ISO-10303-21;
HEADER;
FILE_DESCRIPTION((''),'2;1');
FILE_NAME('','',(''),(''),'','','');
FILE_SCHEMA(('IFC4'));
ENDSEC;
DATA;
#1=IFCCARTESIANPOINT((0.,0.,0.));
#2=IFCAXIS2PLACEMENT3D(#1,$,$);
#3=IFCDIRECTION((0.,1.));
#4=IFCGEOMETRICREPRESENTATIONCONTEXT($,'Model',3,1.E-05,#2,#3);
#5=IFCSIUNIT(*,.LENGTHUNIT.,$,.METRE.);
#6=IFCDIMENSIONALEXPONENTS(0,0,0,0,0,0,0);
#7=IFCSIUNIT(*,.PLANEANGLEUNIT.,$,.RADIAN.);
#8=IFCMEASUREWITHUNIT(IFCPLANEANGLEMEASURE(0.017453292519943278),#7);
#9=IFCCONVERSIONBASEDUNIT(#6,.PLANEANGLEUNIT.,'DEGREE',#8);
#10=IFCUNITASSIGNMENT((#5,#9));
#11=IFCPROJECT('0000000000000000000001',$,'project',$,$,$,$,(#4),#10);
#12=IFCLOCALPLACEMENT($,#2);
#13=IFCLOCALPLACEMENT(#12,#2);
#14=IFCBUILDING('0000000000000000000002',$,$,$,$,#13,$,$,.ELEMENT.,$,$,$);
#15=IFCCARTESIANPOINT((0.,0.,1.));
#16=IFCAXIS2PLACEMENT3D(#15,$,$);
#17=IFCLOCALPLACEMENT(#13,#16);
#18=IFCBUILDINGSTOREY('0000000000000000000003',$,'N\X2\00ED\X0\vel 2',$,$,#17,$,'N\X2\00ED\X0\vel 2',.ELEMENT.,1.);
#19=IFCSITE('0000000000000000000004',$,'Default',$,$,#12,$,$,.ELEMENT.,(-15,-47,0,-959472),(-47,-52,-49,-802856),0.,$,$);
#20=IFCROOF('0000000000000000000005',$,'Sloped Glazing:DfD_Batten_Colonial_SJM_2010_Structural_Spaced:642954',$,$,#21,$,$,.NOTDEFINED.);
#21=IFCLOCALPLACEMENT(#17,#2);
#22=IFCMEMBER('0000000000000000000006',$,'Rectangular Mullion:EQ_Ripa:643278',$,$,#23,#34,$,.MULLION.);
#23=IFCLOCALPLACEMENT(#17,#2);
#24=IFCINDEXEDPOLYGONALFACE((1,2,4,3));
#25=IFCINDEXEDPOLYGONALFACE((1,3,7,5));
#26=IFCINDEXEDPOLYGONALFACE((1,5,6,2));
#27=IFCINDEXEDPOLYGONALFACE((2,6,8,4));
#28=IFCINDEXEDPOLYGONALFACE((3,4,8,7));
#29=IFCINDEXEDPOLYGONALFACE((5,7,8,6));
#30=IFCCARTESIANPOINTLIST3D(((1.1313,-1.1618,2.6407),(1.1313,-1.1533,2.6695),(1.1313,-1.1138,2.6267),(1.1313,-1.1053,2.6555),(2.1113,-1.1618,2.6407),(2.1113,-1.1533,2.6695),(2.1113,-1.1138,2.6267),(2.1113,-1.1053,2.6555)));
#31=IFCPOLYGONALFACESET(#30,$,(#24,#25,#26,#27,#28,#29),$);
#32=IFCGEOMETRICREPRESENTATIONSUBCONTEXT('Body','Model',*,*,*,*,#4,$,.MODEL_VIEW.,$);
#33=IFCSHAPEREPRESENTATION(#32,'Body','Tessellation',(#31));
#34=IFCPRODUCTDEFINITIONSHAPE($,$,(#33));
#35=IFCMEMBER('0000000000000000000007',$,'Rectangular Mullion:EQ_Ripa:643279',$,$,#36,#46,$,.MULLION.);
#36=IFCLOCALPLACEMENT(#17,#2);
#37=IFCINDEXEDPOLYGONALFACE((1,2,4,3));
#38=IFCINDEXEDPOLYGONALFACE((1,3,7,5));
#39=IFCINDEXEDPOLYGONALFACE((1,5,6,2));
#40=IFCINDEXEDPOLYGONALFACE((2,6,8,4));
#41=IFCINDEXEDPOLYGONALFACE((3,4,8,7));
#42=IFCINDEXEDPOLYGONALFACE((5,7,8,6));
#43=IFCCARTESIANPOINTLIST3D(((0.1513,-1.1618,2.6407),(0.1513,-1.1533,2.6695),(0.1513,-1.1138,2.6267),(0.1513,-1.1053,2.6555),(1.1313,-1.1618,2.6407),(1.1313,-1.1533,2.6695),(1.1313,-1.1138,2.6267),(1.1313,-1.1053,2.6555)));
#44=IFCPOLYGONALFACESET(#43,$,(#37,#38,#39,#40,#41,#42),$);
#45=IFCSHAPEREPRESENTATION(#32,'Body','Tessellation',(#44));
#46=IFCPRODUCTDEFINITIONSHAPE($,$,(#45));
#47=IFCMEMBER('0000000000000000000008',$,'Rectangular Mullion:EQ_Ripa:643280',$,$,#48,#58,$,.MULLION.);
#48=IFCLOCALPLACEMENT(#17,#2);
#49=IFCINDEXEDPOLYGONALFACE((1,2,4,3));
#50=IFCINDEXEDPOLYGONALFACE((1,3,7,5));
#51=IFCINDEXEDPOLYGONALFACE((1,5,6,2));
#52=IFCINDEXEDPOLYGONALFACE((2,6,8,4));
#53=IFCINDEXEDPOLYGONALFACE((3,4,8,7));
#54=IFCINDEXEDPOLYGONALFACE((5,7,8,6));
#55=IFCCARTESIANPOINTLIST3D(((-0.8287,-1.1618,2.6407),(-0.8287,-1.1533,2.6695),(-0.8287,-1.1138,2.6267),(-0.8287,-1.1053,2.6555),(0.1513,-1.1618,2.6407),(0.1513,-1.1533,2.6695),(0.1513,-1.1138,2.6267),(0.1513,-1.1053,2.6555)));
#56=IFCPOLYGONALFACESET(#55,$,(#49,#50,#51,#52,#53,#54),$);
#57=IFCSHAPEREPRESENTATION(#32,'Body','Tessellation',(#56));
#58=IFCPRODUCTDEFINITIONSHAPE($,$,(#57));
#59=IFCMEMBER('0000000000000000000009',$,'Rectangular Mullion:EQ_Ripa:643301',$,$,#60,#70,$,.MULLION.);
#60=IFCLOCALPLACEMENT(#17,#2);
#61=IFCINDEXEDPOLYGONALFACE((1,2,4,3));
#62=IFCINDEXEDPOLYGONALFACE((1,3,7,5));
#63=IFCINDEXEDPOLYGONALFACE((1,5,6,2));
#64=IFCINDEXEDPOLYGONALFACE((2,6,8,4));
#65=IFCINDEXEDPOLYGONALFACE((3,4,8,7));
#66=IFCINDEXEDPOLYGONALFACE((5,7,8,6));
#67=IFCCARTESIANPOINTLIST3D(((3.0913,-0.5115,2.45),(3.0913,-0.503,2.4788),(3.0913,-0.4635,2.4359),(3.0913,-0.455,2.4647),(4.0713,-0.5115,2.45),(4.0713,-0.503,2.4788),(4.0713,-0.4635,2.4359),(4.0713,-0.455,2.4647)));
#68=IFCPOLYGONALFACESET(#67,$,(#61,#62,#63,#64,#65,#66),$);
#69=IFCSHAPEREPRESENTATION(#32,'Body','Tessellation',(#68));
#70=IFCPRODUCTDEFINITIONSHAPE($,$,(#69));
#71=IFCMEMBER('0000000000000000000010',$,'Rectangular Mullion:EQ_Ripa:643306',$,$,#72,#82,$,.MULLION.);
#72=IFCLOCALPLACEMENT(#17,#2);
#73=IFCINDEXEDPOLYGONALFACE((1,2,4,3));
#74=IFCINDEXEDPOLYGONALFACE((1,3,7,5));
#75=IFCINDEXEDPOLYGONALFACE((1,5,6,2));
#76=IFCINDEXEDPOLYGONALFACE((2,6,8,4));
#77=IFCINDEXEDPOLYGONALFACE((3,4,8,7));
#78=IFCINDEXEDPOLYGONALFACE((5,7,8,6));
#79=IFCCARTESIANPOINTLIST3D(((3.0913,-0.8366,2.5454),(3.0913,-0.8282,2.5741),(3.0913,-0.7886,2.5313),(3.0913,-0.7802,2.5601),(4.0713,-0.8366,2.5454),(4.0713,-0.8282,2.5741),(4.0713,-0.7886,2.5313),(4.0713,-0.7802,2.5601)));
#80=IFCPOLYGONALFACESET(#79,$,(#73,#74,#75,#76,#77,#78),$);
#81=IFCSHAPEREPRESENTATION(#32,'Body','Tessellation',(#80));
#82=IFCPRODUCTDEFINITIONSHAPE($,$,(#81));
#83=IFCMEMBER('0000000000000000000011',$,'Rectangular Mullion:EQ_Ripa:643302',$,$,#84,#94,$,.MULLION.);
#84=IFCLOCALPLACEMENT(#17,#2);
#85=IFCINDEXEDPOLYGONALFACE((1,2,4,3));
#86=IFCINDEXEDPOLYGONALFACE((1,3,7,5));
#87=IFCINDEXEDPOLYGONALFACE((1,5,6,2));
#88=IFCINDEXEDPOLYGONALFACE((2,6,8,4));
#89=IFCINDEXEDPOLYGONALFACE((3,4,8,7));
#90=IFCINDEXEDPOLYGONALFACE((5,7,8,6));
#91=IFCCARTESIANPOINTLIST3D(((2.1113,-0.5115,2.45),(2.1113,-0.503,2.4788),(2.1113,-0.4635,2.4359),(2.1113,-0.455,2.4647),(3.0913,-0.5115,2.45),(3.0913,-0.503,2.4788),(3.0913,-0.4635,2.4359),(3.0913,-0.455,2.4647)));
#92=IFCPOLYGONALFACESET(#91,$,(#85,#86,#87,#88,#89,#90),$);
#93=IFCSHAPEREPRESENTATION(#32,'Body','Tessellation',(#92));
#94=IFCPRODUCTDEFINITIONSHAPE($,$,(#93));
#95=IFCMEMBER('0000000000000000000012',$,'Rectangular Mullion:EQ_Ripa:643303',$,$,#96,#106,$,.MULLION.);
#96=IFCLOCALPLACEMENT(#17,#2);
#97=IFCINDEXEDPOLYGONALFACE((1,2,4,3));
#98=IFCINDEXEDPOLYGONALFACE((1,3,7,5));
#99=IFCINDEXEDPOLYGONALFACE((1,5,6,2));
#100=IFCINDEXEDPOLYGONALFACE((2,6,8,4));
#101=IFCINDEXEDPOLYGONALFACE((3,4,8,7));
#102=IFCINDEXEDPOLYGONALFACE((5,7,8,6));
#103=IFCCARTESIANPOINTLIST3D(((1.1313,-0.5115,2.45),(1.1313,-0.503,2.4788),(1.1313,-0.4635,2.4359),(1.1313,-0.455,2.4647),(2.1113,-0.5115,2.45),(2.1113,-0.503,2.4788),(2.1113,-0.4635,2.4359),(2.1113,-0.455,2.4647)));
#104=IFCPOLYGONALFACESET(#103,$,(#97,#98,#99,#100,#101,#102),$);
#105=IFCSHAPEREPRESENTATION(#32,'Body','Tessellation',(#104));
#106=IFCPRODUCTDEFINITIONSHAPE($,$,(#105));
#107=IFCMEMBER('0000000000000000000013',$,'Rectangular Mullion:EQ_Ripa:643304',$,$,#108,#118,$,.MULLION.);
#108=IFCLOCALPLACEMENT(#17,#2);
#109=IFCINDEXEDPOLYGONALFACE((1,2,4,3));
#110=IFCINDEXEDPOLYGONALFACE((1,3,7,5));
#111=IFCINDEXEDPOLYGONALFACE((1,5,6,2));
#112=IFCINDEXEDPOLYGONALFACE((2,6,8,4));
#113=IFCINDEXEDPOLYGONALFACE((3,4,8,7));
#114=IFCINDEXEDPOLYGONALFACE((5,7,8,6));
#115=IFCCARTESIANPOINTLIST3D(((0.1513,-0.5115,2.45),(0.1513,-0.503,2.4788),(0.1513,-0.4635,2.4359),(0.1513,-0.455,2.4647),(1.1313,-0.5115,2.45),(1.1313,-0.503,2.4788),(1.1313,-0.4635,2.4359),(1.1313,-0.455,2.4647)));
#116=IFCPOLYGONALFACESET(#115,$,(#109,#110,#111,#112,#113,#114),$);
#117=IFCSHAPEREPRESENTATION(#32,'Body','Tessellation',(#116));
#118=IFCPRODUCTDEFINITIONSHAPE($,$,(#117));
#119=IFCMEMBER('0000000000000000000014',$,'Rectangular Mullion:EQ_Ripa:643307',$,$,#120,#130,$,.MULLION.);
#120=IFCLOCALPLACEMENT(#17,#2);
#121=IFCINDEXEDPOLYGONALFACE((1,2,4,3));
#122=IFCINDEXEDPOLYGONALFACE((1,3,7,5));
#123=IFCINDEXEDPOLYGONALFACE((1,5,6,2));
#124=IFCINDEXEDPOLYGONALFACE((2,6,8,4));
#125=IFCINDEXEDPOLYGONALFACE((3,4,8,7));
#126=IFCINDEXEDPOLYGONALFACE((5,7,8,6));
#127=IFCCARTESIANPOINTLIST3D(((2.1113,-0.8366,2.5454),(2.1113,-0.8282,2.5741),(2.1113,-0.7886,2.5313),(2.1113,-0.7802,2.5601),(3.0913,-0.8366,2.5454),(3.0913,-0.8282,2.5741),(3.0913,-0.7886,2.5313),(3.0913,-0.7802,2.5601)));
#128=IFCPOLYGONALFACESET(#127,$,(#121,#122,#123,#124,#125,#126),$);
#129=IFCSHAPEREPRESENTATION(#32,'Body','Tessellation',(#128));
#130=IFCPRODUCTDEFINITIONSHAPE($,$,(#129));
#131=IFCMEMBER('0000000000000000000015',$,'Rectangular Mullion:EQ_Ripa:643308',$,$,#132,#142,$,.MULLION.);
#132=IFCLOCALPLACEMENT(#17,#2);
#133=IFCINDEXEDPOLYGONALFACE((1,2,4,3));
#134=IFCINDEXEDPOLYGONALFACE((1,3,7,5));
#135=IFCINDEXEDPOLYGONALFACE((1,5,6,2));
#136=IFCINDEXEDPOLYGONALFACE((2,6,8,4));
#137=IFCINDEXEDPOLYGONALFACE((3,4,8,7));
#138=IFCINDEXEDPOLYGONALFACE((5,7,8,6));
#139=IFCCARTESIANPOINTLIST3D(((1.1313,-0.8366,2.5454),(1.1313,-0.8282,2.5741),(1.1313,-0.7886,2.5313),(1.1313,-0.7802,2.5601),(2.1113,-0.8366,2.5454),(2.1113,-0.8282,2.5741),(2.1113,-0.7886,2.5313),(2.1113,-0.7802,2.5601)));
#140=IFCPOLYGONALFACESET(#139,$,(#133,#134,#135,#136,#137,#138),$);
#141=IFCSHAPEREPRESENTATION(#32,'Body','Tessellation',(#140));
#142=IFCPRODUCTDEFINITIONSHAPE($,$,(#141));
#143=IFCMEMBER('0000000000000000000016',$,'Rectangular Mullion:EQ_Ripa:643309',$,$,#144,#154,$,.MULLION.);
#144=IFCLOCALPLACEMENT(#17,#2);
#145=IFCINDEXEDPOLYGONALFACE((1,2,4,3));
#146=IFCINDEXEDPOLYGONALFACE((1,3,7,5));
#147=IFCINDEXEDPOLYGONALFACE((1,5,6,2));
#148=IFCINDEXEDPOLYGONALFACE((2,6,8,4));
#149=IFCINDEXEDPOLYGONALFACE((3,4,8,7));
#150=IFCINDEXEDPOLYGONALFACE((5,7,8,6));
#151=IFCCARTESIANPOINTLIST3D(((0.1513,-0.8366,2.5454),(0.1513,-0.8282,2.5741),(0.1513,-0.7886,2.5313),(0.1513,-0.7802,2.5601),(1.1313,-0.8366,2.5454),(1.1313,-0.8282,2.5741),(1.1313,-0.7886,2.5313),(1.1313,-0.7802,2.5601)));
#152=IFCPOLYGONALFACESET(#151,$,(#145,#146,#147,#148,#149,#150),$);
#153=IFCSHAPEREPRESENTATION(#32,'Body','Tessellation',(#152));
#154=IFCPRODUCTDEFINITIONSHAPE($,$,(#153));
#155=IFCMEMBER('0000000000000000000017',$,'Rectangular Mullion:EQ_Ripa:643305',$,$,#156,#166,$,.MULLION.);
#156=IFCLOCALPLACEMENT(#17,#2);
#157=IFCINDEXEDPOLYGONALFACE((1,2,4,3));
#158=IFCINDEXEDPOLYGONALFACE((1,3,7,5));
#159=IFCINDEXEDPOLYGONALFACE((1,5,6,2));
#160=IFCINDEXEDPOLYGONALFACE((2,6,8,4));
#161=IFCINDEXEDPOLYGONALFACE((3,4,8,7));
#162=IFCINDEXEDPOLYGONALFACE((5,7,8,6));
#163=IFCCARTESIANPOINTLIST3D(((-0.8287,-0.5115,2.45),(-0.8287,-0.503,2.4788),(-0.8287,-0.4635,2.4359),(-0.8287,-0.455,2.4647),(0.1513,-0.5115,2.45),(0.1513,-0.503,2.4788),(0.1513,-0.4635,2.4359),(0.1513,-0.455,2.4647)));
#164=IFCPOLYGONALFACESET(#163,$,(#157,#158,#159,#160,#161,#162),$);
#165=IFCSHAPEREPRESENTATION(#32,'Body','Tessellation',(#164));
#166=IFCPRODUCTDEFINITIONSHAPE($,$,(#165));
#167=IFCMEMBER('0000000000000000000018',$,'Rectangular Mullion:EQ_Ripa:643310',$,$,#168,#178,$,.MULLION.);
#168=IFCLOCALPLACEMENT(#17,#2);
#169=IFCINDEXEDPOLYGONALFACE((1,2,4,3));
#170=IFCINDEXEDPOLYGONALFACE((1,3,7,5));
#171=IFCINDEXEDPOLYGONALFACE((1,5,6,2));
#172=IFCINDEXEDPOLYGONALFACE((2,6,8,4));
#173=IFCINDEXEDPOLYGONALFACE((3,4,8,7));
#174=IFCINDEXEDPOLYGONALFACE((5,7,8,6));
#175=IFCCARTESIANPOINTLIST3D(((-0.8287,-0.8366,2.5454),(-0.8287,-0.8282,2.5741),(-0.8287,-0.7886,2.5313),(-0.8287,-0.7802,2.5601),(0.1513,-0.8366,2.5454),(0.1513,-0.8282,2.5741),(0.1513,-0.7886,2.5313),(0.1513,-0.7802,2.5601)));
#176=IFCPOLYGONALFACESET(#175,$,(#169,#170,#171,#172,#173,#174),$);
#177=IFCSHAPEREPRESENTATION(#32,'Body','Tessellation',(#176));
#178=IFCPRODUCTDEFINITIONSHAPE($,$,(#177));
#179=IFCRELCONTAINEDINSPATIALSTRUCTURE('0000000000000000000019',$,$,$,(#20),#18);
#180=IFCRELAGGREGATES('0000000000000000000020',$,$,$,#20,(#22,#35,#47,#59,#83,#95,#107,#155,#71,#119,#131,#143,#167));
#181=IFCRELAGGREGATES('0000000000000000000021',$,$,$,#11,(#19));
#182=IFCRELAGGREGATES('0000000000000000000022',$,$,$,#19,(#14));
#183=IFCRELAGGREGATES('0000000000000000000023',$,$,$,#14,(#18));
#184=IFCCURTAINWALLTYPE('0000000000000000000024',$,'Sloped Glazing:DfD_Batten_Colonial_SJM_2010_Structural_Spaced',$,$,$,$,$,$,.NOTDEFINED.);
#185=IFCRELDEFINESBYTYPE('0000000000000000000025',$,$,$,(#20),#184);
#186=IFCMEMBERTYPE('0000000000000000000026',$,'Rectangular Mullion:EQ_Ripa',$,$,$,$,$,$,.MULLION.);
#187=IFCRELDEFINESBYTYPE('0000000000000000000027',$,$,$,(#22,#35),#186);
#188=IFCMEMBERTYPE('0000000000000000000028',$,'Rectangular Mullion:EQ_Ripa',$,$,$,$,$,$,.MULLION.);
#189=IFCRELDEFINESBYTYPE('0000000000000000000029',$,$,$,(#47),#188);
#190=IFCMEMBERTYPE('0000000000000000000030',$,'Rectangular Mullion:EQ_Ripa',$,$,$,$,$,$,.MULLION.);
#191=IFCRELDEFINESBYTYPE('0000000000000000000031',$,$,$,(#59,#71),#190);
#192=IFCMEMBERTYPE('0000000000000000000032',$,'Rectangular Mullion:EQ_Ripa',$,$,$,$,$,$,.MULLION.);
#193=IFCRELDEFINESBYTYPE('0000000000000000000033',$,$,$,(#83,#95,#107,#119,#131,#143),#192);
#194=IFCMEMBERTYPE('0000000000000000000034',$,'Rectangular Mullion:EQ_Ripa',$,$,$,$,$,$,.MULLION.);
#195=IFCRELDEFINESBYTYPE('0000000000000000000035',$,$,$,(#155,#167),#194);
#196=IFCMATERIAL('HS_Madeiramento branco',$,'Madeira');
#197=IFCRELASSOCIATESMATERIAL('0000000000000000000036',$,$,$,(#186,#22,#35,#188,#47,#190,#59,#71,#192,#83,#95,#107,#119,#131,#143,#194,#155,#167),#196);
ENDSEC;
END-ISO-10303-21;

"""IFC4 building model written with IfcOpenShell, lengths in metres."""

from ifc_helpers import new_model, entity, si_unit, converted_unit, direction, frame, origin, place, context, subcontext, project, spatial, indexed_curve, outline, extrude, source, transform, mapped, material, type_object, type_shapes, element, aggregate, save


model = new_model("IFC4")

# Units and contexts
model_context = context("Model", 3, precision=1e-05, world=origin(), true_north=direction((0.0, 1.0)))
body_context = subcontext(model_context, "Body", "Model", "MODEL_VIEW")
ifc_project = project(units=[si_unit("LENGTHUNIT", "METRE"), converted_unit("PLANEANGLEUNIT", "DEGREE", entity("IfcPlaneAngleMeasure", 0.017453292519943278), si_unit("PLANEANGLEUNIT", "RADIAN"), dimensions=[0, 0, 0, 0, 0, 0, 0])], contexts=[model_context])

# Site, building, storey
site_placement = place(None, origin())
site = spatial("IfcSite", under=ifc_project, at=site_placement, Name="Default", CompositionType="ELEMENT", RefLatitude=(-15, -47, 0, -959472), RefLongitude=(-47, -52, -49, -802856), RefElevation=0.0)
building_placement = place(site_placement, origin())
building = spatial("IfcBuilding", under=site, at=building_placement, CompositionType="ELEMENT")
storey_placement = place(building_placement, frame((0.0, 0.0, 1.0)))
storey = spatial("IfcBuildingStorey", under=building, at=storey_placement, Name="Nível 2", LongName="Nível 2", CompositionType="ELEMENT", Elevation=1.0)

# Roof, members
ifc_material_1 = material(Name="HS_Madeiramento branco", Category="Madeira")
curtain_wall_type_1 = type_object("IfcCurtainWallType", Name="Sloped Glazing:DfD_Batten_Colonial_SJM_2010_Structural_Spaced", PredefinedType="NOTDEFINED")
roof_1_placement = place(storey_placement, frame((0.0, 0.0, -1.0)))
roof_1 = element("IfcRoof", 1, at=roof_1_placement, inside=storey, type_object=curtain_wall_type_1, Name="Sloped Glazing:DfD_Batten_Colonial_SJM_2010_Structural_Spaced:642954", PredefinedType="NOTDEFINED")
member_type_1 = type_object("IfcMemberType", Name="Rectangular Mullion:EQ_Ripa", PredefinedType="MULLION", material=ifc_material_1)
shared_shape_1 = source(origin(), body_context, "Body", "SweptSolid", [
    extrude(outline(indexed_curve([(-0.025, -0.015), (0.025, -0.015), (0.025, 0.015), (-0.025, 0.015), (-0.025, -0.015)], self_intersect=False)), frame((-0.025, 0.0, -0.98), z_axis=(0.0, 0.0, 1.0), x_axis=(-1.0, 0.0, 0.0)), (0.0, 0.0, 1.0), 0.98),
])
type_shapes(member_type_1, [shared_shape_1])
member_1_placement = place(roof_1_placement, frame((2.1113, -1.1575, 3.6551), z_axis=(1.0, 0.0, 0.0), x_axis=(0.0, -0.95956, 0.281504)))
member_1 = element("IfcMember", 2, at=member_1_placement, type_object=member_type_1, material=ifc_material_1, Name="Rectangular Mullion:EQ_Ripa:643278", PredefinedType="MULLION", context=body_context, shape_type="MappedRepresentation", body=[
    mapped(shared_shape_1, transform((0.0, 0.0, 0.0), scale=1.0)),
])
member_2_placement = place(roof_1_placement, frame((1.1313, -1.1575, 3.6551), z_axis=(1.0, 0.0, 0.0), x_axis=(0.0, -0.95956, 0.281504)))
member_2 = element("IfcMember", 3, at=member_2_placement, type_object=member_type_1, material=ifc_material_1, Name="Rectangular Mullion:EQ_Ripa:643279", PredefinedType="MULLION", context=body_context, shape_type="MappedRepresentation", body=[
    mapped(shared_shape_1, transform((0.0, 0.0, 0.0), scale=1.0)),
])
member_type_2 = type_object("IfcMemberType", Name="Rectangular Mullion:EQ_Ripa", PredefinedType="MULLION", material=ifc_material_1)
shared_shape_2 = source(origin(), body_context, "Body", "SweptSolid", [
    extrude(outline(indexed_curve([(-0.025, -0.015), (0.025, -0.015), (0.025, 0.015), (-0.025, 0.015), (-0.025, -0.015)], self_intersect=False)), frame((-0.025, 0.0, -0.98), z_axis=(0.0, 0.0, 1.0), x_axis=(-1.0, 0.0, 0.0)), (0.0, 0.0, 1.0), 0.98),
])
type_shapes(member_type_2, [shared_shape_2])
member_3_placement = place(roof_1_placement, frame((0.1513, -1.1575, 3.6551), z_axis=(1.0, 0.0, 0.0), x_axis=(0.0, -0.95956, 0.281504)))
member_3 = element("IfcMember", 4, at=member_3_placement, type_object=member_type_2, material=ifc_material_1, Name="Rectangular Mullion:EQ_Ripa:643280", PredefinedType="MULLION", context=body_context, shape_type="MappedRepresentation", body=[
    mapped(shared_shape_2, transform((0.0, 0.0, 0.0), scale=1.0)),
])
member_type_3 = type_object("IfcMemberType", Name="Rectangular Mullion:EQ_Ripa", PredefinedType="MULLION", material=ifc_material_1)
shared_shape_3 = source(origin(), body_context, "Body", "SweptSolid", [
    extrude(outline(indexed_curve([(-0.025, -0.015), (0.025, -0.015), (0.025, 0.015), (-0.025, 0.015), (-0.025, -0.015)], self_intersect=False)), frame((0.0, 0.0, -0.98), z_axis=(0.0, 0.0, 1.0), x_axis=(-1.0, 0.0, 0.0)), (0.0, 0.0, 1.0), 0.98),
])
type_shapes(member_type_3, [shared_shape_3])
member_4_placement = place(roof_1_placement, frame((4.0713, -0.4833, 3.4573), z_axis=(1.0, 0.0, 0.0), x_axis=(0.0, -0.95956, 0.281504)))
member_4 = element("IfcMember", 5, at=member_4_placement, type_object=member_type_3, material=ifc_material_1, Name="Rectangular Mullion:EQ_Ripa:643301", PredefinedType="MULLION", context=body_context, shape_type="MappedRepresentation", body=[
    mapped(shared_shape_3, transform((0.0, 0.0, 0.0), scale=1.0)),
])
member_5_placement = place(roof_1_placement, frame((4.0713, -0.8084, 3.5527), z_axis=(1.0, 0.0, 0.0), x_axis=(0.0, -0.95956, 0.281504)))
member_5 = element("IfcMember", 6, at=member_5_placement, type_object=member_type_3, material=ifc_material_1, Name="Rectangular Mullion:EQ_Ripa:643306", PredefinedType="MULLION", context=body_context, shape_type="MappedRepresentation", body=[
    mapped(shared_shape_3, transform((0.0, 0.0, 0.0), scale=1.0)),
])
member_type_4 = type_object("IfcMemberType", Name="Rectangular Mullion:EQ_Ripa", PredefinedType="MULLION", material=ifc_material_1)
shared_shape_4 = source(origin(), body_context, "Body", "SweptSolid", [
    extrude(outline(indexed_curve([(-0.025, -0.015), (0.025, -0.015), (0.025, 0.015), (-0.025, 0.015), (-0.025, -0.015)], self_intersect=False)), frame((0.0, 0.0, -0.98), z_axis=(0.0, 0.0, 1.0), x_axis=(-1.0, 0.0, 0.0)), (0.0, 0.0, 1.0), 0.98),
])
type_shapes(member_type_4, [shared_shape_4])
member_6_placement = place(roof_1_placement, frame((3.0913, -0.4833, 3.4573), z_axis=(1.0, 0.0, 0.0), x_axis=(0.0, -0.95956, 0.281504)))
member_6 = element("IfcMember", 7, at=member_6_placement, type_object=member_type_4, material=ifc_material_1, Name="Rectangular Mullion:EQ_Ripa:643302", PredefinedType="MULLION", context=body_context, shape_type="MappedRepresentation", body=[
    mapped(shared_shape_4, transform((0.0, 0.0, 0.0), scale=1.0)),
])
member_7_placement = place(roof_1_placement, frame((2.1113, -0.4833, 3.4573), z_axis=(1.0, 0.0, 0.0), x_axis=(0.0, -0.95956, 0.281504)))
member_7 = element("IfcMember", 8, at=member_7_placement, type_object=member_type_4, material=ifc_material_1, Name="Rectangular Mullion:EQ_Ripa:643303", PredefinedType="MULLION", context=body_context, shape_type="MappedRepresentation", body=[
    mapped(shared_shape_4, transform((0.0, 0.0, 0.0), scale=1.0)),
])
member_8_placement = place(roof_1_placement, frame((1.1313, -0.4833, 3.4573), z_axis=(1.0, 0.0, 0.0), x_axis=(0.0, -0.95956, 0.281504)))
member_8 = element("IfcMember", 9, at=member_8_placement, type_object=member_type_4, material=ifc_material_1, Name="Rectangular Mullion:EQ_Ripa:643304", PredefinedType="MULLION", context=body_context, shape_type="MappedRepresentation", body=[
    mapped(shared_shape_4, transform((0.0, 0.0, 0.0), scale=1.0)),
])
member_9_placement = place(roof_1_placement, frame((3.0913, -0.8084, 3.5527), z_axis=(1.0, 0.0, 0.0), x_axis=(0.0, -0.95956, 0.281504)))
member_9 = element("IfcMember", 10, at=member_9_placement, type_object=member_type_4, material=ifc_material_1, Name="Rectangular Mullion:EQ_Ripa:643307", PredefinedType="MULLION", context=body_context, shape_type="MappedRepresentation", body=[
    mapped(shared_shape_4, transform((0.0, 0.0, 0.0), scale=1.0)),
])
member_10_placement = place(roof_1_placement, frame((2.1113, -0.8084, 3.5527), z_axis=(1.0, 0.0, 0.0), x_axis=(0.0, -0.95956, 0.281504)))
member_10 = element("IfcMember", 11, at=member_10_placement, type_object=member_type_4, material=ifc_material_1, Name="Rectangular Mullion:EQ_Ripa:643308", PredefinedType="MULLION", context=body_context, shape_type="MappedRepresentation", body=[
    mapped(shared_shape_4, transform((0.0, 0.0, 0.0), scale=1.0)),
])
member_11_placement = place(roof_1_placement, frame((1.1313, -0.8084, 3.5527), z_axis=(1.0, 0.0, 0.0), x_axis=(0.0, -0.95956, 0.281504)))
member_11 = element("IfcMember", 12, at=member_11_placement, type_object=member_type_4, material=ifc_material_1, Name="Rectangular Mullion:EQ_Ripa:643309", PredefinedType="MULLION", context=body_context, shape_type="MappedRepresentation", body=[
    mapped(shared_shape_4, transform((0.0, 0.0, 0.0), scale=1.0)),
])
member_type_5 = type_object("IfcMemberType", Name="Rectangular Mullion:EQ_Ripa", PredefinedType="MULLION", material=ifc_material_1)
shared_shape_5 = source(origin(), body_context, "Body", "SweptSolid", [
    extrude(outline(indexed_curve([(-0.025, -0.015), (0.025, -0.015), (0.025, 0.015), (-0.025, 0.015), (-0.025, -0.015)], self_intersect=False)), frame((0.0, 0.0, -0.98), z_axis=(0.0, 0.0, 1.0), x_axis=(-1.0, 0.0, 0.0)), (0.0, 0.0, 1.0), 0.98),
])
type_shapes(member_type_5, [shared_shape_5])
member_12_placement = place(roof_1_placement, frame((0.1513, -0.4833, 3.4573), z_axis=(1.0, 0.0, 0.0), x_axis=(0.0, -0.95956, 0.281504)))
member_12 = element("IfcMember", 13, at=member_12_placement, type_object=member_type_5, material=ifc_material_1, Name="Rectangular Mullion:EQ_Ripa:643305", PredefinedType="MULLION", context=body_context, shape_type="MappedRepresentation", body=[
    mapped(shared_shape_5, transform((0.0, 0.0, 0.0), scale=1.0)),
])
member_13_placement = place(roof_1_placement, frame((0.1513, -0.8084, 3.5527), z_axis=(1.0, 0.0, 0.0), x_axis=(0.0, -0.95956, 0.281504)))
member_13 = element("IfcMember", 14, at=member_13_placement, type_object=member_type_5, material=ifc_material_1, Name="Rectangular Mullion:EQ_Ripa:643310", PredefinedType="MULLION", context=body_context, shape_type="MappedRepresentation", body=[
    mapped(shared_shape_5, transform((0.0, 0.0, 0.0), scale=1.0)),
])
aggregate(roof_1, [member_1, member_2, member_3, member_4, member_6, member_7, member_8, member_12, member_5, member_9, member_10, member_11, member_13])

save(model, "model.ifc")
